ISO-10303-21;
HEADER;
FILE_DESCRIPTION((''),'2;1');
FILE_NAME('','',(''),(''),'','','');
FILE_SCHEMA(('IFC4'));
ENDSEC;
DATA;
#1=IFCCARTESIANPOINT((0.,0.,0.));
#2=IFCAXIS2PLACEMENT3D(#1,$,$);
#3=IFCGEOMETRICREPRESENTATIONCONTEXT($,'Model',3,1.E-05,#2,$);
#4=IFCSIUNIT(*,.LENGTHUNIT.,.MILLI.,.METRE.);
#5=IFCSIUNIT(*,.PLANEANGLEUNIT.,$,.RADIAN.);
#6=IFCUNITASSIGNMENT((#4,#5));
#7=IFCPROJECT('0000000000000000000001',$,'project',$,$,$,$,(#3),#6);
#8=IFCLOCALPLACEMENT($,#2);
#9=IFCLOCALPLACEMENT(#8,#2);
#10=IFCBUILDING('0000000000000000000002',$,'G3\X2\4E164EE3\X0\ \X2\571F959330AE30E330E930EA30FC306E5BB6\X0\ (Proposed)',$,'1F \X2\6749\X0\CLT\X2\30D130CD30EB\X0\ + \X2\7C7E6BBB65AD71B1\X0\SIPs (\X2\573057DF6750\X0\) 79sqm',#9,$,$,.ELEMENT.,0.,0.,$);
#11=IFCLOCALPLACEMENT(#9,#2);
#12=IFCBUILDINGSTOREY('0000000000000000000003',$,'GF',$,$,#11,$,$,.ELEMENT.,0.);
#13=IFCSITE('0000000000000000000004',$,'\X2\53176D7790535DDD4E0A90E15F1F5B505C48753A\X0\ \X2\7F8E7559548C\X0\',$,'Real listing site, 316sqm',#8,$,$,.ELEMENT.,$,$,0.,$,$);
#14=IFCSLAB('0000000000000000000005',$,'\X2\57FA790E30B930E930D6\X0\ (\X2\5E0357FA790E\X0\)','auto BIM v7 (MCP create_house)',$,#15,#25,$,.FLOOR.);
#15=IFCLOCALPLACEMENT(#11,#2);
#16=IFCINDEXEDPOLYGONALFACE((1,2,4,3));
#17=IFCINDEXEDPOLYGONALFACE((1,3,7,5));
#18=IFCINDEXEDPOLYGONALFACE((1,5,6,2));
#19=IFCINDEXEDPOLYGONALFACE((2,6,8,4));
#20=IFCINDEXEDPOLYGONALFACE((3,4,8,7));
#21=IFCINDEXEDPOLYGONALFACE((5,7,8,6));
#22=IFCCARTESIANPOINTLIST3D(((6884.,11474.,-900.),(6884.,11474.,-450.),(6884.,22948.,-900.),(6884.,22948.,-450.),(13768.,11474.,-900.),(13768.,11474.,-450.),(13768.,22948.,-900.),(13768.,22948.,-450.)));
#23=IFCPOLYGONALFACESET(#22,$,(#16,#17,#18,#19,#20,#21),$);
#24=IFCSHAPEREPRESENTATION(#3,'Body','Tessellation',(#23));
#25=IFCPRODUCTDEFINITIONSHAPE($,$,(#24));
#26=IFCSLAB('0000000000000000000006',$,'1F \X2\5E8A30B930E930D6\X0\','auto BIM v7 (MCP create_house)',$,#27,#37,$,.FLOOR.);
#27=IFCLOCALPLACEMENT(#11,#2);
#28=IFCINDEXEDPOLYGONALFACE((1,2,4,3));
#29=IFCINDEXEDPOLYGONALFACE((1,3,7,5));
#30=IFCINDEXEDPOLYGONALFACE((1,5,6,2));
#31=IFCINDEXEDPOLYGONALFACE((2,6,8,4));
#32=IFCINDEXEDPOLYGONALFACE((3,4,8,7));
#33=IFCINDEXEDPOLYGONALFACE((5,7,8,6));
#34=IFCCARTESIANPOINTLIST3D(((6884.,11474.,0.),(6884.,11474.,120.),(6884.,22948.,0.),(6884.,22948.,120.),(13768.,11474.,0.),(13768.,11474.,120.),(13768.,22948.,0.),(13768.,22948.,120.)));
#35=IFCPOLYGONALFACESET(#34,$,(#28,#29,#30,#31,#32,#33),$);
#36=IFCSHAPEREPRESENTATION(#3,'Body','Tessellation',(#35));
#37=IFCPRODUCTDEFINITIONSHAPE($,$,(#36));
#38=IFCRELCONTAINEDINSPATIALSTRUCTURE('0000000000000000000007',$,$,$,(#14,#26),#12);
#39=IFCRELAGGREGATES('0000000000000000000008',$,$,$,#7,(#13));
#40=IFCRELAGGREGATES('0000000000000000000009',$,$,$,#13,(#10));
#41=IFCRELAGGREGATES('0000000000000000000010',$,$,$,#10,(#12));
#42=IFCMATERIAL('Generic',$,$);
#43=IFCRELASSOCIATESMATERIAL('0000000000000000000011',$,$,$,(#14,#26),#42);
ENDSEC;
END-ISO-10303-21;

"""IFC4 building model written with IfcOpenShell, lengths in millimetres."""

from ifc_helpers import new_model, si_unit, frame, frame_2d, origin, place, context, project, spatial, rectangle, extrude, material, element, save


model = new_model("IFC4")

# Units and contexts
model_context = context("Model", 3, precision=1e-05, world=origin())
ifc_project = project(units=[si_unit("LENGTHUNIT", "METRE", prefix="MILLI"), si_unit("PLANEANGLEUNIT", "RADIAN")], contexts=[model_context])

# Site, building, storey
site_placement = place(None, origin())
site = spatial("IfcSite", under=ifc_project, at=site_placement, Name="北海道川上郡弟子屈町 美留和", ObjectType="Real listing site, 316sqm", CompositionType="ELEMENT", RefElevation=0.0)
building_placement = place(site_placement, origin())
building = spatial("IfcBuilding", under=site, at=building_placement, Name="G3世代 土間ギャラリーの家 (Proposed)", ObjectType="1F 杉CLTパネル + 籾殻断熱SIPs (地域材) 79sqm", CompositionType="ELEMENT", ElevationOfRefHeight=0.0, ElevationOfTerrain=0.0)
storey_placement = place(building_placement, origin())
storey = spatial("IfcBuildingStorey", under=building, at=storey_placement, Name="GF", CompositionType="ELEMENT", Elevation=0.0)

# Slabs
ifc_material = material(Name="Generic")
slab_1_placement = place(storey_placement, frame((3442.0, 5737.0, -450.0)))
element("IfcSlab", 1, at=slab_1_placement, inside=storey, material=ifc_material, Name="基礎スラブ (布基礎)", Description="auto BIM v7 (MCP create_house)", PredefinedType="FLOOR", context=model_context, shape_type="SweptSolid", body=[
    extrude(rectangle(XDim=6884.0, YDim=11474.0, at=frame_2d((3442.0, 5737.0))), frame((3442.0, 5737.0, -450.0)), (0.0, 0.0, 1.0), 450.0),
])
slab_2_placement = place(storey_placement, frame((3442.0, 5737.0, 0.0)))
element("IfcSlab", 2, at=slab_2_placement, inside=storey, material=ifc_material, Name="1F 床スラブ", Description="auto BIM v7 (MCP create_house)", PredefinedType="FLOOR", context=model_context, shape_type="SweptSolid", body=[
    extrude(rectangle(XDim=6884.0, YDim=11474.0, at=frame_2d((3442.0, 5737.0))), frame((3442.0, 5737.0, 0.0)), (0.0, 0.0, 1.0), 120.0),
])

save(model, "model.ifc")
